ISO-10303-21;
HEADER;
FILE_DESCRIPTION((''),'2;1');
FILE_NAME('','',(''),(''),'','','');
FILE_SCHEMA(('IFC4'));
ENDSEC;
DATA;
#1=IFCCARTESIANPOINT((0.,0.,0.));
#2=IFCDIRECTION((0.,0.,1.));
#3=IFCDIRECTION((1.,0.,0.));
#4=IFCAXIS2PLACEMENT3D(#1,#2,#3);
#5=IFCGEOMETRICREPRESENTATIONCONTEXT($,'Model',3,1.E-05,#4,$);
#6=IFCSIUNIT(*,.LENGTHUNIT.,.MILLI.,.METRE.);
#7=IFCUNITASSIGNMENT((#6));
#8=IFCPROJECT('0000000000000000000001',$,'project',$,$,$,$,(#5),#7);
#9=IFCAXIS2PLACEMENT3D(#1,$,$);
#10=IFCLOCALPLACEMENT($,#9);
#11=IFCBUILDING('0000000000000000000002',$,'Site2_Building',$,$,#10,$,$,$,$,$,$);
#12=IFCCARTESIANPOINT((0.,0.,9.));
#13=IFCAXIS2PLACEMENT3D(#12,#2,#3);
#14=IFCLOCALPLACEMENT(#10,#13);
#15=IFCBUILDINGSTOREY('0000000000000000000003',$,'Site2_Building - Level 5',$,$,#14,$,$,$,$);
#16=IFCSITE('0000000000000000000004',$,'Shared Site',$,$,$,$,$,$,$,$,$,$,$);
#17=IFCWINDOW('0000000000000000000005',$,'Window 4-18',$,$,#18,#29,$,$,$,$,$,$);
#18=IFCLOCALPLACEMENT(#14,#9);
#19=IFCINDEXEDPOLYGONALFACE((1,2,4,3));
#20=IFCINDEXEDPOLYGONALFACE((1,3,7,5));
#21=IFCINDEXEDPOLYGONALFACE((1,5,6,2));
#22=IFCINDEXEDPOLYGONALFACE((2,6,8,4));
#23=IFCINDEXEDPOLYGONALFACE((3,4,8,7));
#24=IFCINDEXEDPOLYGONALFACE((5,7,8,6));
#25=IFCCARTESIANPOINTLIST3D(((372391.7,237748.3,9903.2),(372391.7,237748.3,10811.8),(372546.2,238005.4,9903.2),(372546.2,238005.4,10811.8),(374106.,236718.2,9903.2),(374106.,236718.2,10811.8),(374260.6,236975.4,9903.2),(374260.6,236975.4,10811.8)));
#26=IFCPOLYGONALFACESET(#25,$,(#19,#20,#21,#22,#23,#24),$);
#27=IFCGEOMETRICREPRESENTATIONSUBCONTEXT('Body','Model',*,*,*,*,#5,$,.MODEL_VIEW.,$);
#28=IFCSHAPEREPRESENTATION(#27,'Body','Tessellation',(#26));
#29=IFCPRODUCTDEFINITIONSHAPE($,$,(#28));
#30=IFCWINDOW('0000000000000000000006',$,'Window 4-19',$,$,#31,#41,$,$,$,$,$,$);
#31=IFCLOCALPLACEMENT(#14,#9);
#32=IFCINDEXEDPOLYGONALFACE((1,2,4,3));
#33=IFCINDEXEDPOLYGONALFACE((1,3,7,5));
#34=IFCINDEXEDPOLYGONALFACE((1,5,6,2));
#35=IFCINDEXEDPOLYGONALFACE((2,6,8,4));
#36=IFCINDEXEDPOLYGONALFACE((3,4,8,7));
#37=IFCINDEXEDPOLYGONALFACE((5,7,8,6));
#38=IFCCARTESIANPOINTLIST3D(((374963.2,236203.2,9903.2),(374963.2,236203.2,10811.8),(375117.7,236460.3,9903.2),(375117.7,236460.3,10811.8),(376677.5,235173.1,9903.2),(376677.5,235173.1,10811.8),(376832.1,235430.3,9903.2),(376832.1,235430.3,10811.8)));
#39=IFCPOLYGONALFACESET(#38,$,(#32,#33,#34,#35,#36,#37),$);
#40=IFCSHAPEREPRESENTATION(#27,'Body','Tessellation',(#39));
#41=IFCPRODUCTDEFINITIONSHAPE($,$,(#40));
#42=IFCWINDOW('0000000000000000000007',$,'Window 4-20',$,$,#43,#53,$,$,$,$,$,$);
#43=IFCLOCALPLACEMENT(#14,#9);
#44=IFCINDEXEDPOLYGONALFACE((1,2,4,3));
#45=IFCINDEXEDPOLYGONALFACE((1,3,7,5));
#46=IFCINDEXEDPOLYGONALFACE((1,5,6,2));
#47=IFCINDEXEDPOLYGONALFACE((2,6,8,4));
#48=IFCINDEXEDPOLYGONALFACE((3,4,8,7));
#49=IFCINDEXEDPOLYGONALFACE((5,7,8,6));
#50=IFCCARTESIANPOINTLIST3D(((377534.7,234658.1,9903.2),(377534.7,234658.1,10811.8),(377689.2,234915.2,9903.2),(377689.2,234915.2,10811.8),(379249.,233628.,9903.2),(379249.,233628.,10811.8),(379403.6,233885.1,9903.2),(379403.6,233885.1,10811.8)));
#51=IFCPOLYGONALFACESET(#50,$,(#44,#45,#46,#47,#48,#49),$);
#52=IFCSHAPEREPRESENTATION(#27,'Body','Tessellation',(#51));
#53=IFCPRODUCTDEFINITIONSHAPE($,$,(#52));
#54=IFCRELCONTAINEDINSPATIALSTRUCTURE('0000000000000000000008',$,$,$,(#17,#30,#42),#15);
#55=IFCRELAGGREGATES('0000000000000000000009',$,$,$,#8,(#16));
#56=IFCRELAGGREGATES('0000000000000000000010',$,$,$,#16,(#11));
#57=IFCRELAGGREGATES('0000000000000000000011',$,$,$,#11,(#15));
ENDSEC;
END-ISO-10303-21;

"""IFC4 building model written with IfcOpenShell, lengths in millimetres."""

from ifc_helpers import new_model, si_unit, frame, origin, origin_with_axes, place, context, subcontext, project, spatial, indexed_curve, outline, extrude, element, save


model = new_model("IFC4")

# Units and contexts
model_context = context("Model", 3, precision=1e-05, world=origin_with_axes())
body_context = subcontext(model_context, "Body", "Model", "MODEL_VIEW")
ifc_project = project(units=[si_unit("LENGTHUNIT", "METRE", prefix="MILLI")], contexts=[model_context])

# Site, building, storey
site = spatial("IfcSite", under=ifc_project, Name="Shared Site")
building_placement = place(None, origin())
building = spatial("IfcBuilding", under=site, at=building_placement, Name="Site2_Building")
storey_placement = place(building_placement, frame((0.0, 0.0, 9.0), z_axis=(0.0, 0.0, 1.0), x_axis=(1.0, 0.0, 0.0)))
storey = spatial("IfcBuildingStorey", under=building, at=storey_placement, Name="Site2_Building - Level 5")

# Windows
for number, where, z_axis, x_axis, name in (
    (1, (372391.7, 237748.3, 9903.2), (0.0, 0.0, 1.0), (0.857167, -0.515038, 0.0), "Window 4-18"),
    (2, (374963.2, 236203.2, 9903.2), (0.0, 0.0, 1.0), (0.857167, -0.515038, 0.0), "Window 4-19"),
    (3, (377534.7, 234658.1, 9903.2), (0.0, 0.0, 1.0), (0.857167, -0.515038, 0.0), "Window 4-20"),
):
    element("IfcWindow", number, at=place(storey_placement, frame(where, z_axis=z_axis, x_axis=x_axis)), inside=storey, Name=name, context=body_context, shape_type="SweptSolid", body=[
        extrude(outline(indexed_curve([(0.0, 0.0), (0.0, 300.0), (2000.0, 300.0), (2000.0, 0.0), (0.0, 0.0)], self_intersect=False)), origin_with_axes(), (0.0, 0.0, 1.0), 908.6),
    ])

save(model, "model.ifc")
